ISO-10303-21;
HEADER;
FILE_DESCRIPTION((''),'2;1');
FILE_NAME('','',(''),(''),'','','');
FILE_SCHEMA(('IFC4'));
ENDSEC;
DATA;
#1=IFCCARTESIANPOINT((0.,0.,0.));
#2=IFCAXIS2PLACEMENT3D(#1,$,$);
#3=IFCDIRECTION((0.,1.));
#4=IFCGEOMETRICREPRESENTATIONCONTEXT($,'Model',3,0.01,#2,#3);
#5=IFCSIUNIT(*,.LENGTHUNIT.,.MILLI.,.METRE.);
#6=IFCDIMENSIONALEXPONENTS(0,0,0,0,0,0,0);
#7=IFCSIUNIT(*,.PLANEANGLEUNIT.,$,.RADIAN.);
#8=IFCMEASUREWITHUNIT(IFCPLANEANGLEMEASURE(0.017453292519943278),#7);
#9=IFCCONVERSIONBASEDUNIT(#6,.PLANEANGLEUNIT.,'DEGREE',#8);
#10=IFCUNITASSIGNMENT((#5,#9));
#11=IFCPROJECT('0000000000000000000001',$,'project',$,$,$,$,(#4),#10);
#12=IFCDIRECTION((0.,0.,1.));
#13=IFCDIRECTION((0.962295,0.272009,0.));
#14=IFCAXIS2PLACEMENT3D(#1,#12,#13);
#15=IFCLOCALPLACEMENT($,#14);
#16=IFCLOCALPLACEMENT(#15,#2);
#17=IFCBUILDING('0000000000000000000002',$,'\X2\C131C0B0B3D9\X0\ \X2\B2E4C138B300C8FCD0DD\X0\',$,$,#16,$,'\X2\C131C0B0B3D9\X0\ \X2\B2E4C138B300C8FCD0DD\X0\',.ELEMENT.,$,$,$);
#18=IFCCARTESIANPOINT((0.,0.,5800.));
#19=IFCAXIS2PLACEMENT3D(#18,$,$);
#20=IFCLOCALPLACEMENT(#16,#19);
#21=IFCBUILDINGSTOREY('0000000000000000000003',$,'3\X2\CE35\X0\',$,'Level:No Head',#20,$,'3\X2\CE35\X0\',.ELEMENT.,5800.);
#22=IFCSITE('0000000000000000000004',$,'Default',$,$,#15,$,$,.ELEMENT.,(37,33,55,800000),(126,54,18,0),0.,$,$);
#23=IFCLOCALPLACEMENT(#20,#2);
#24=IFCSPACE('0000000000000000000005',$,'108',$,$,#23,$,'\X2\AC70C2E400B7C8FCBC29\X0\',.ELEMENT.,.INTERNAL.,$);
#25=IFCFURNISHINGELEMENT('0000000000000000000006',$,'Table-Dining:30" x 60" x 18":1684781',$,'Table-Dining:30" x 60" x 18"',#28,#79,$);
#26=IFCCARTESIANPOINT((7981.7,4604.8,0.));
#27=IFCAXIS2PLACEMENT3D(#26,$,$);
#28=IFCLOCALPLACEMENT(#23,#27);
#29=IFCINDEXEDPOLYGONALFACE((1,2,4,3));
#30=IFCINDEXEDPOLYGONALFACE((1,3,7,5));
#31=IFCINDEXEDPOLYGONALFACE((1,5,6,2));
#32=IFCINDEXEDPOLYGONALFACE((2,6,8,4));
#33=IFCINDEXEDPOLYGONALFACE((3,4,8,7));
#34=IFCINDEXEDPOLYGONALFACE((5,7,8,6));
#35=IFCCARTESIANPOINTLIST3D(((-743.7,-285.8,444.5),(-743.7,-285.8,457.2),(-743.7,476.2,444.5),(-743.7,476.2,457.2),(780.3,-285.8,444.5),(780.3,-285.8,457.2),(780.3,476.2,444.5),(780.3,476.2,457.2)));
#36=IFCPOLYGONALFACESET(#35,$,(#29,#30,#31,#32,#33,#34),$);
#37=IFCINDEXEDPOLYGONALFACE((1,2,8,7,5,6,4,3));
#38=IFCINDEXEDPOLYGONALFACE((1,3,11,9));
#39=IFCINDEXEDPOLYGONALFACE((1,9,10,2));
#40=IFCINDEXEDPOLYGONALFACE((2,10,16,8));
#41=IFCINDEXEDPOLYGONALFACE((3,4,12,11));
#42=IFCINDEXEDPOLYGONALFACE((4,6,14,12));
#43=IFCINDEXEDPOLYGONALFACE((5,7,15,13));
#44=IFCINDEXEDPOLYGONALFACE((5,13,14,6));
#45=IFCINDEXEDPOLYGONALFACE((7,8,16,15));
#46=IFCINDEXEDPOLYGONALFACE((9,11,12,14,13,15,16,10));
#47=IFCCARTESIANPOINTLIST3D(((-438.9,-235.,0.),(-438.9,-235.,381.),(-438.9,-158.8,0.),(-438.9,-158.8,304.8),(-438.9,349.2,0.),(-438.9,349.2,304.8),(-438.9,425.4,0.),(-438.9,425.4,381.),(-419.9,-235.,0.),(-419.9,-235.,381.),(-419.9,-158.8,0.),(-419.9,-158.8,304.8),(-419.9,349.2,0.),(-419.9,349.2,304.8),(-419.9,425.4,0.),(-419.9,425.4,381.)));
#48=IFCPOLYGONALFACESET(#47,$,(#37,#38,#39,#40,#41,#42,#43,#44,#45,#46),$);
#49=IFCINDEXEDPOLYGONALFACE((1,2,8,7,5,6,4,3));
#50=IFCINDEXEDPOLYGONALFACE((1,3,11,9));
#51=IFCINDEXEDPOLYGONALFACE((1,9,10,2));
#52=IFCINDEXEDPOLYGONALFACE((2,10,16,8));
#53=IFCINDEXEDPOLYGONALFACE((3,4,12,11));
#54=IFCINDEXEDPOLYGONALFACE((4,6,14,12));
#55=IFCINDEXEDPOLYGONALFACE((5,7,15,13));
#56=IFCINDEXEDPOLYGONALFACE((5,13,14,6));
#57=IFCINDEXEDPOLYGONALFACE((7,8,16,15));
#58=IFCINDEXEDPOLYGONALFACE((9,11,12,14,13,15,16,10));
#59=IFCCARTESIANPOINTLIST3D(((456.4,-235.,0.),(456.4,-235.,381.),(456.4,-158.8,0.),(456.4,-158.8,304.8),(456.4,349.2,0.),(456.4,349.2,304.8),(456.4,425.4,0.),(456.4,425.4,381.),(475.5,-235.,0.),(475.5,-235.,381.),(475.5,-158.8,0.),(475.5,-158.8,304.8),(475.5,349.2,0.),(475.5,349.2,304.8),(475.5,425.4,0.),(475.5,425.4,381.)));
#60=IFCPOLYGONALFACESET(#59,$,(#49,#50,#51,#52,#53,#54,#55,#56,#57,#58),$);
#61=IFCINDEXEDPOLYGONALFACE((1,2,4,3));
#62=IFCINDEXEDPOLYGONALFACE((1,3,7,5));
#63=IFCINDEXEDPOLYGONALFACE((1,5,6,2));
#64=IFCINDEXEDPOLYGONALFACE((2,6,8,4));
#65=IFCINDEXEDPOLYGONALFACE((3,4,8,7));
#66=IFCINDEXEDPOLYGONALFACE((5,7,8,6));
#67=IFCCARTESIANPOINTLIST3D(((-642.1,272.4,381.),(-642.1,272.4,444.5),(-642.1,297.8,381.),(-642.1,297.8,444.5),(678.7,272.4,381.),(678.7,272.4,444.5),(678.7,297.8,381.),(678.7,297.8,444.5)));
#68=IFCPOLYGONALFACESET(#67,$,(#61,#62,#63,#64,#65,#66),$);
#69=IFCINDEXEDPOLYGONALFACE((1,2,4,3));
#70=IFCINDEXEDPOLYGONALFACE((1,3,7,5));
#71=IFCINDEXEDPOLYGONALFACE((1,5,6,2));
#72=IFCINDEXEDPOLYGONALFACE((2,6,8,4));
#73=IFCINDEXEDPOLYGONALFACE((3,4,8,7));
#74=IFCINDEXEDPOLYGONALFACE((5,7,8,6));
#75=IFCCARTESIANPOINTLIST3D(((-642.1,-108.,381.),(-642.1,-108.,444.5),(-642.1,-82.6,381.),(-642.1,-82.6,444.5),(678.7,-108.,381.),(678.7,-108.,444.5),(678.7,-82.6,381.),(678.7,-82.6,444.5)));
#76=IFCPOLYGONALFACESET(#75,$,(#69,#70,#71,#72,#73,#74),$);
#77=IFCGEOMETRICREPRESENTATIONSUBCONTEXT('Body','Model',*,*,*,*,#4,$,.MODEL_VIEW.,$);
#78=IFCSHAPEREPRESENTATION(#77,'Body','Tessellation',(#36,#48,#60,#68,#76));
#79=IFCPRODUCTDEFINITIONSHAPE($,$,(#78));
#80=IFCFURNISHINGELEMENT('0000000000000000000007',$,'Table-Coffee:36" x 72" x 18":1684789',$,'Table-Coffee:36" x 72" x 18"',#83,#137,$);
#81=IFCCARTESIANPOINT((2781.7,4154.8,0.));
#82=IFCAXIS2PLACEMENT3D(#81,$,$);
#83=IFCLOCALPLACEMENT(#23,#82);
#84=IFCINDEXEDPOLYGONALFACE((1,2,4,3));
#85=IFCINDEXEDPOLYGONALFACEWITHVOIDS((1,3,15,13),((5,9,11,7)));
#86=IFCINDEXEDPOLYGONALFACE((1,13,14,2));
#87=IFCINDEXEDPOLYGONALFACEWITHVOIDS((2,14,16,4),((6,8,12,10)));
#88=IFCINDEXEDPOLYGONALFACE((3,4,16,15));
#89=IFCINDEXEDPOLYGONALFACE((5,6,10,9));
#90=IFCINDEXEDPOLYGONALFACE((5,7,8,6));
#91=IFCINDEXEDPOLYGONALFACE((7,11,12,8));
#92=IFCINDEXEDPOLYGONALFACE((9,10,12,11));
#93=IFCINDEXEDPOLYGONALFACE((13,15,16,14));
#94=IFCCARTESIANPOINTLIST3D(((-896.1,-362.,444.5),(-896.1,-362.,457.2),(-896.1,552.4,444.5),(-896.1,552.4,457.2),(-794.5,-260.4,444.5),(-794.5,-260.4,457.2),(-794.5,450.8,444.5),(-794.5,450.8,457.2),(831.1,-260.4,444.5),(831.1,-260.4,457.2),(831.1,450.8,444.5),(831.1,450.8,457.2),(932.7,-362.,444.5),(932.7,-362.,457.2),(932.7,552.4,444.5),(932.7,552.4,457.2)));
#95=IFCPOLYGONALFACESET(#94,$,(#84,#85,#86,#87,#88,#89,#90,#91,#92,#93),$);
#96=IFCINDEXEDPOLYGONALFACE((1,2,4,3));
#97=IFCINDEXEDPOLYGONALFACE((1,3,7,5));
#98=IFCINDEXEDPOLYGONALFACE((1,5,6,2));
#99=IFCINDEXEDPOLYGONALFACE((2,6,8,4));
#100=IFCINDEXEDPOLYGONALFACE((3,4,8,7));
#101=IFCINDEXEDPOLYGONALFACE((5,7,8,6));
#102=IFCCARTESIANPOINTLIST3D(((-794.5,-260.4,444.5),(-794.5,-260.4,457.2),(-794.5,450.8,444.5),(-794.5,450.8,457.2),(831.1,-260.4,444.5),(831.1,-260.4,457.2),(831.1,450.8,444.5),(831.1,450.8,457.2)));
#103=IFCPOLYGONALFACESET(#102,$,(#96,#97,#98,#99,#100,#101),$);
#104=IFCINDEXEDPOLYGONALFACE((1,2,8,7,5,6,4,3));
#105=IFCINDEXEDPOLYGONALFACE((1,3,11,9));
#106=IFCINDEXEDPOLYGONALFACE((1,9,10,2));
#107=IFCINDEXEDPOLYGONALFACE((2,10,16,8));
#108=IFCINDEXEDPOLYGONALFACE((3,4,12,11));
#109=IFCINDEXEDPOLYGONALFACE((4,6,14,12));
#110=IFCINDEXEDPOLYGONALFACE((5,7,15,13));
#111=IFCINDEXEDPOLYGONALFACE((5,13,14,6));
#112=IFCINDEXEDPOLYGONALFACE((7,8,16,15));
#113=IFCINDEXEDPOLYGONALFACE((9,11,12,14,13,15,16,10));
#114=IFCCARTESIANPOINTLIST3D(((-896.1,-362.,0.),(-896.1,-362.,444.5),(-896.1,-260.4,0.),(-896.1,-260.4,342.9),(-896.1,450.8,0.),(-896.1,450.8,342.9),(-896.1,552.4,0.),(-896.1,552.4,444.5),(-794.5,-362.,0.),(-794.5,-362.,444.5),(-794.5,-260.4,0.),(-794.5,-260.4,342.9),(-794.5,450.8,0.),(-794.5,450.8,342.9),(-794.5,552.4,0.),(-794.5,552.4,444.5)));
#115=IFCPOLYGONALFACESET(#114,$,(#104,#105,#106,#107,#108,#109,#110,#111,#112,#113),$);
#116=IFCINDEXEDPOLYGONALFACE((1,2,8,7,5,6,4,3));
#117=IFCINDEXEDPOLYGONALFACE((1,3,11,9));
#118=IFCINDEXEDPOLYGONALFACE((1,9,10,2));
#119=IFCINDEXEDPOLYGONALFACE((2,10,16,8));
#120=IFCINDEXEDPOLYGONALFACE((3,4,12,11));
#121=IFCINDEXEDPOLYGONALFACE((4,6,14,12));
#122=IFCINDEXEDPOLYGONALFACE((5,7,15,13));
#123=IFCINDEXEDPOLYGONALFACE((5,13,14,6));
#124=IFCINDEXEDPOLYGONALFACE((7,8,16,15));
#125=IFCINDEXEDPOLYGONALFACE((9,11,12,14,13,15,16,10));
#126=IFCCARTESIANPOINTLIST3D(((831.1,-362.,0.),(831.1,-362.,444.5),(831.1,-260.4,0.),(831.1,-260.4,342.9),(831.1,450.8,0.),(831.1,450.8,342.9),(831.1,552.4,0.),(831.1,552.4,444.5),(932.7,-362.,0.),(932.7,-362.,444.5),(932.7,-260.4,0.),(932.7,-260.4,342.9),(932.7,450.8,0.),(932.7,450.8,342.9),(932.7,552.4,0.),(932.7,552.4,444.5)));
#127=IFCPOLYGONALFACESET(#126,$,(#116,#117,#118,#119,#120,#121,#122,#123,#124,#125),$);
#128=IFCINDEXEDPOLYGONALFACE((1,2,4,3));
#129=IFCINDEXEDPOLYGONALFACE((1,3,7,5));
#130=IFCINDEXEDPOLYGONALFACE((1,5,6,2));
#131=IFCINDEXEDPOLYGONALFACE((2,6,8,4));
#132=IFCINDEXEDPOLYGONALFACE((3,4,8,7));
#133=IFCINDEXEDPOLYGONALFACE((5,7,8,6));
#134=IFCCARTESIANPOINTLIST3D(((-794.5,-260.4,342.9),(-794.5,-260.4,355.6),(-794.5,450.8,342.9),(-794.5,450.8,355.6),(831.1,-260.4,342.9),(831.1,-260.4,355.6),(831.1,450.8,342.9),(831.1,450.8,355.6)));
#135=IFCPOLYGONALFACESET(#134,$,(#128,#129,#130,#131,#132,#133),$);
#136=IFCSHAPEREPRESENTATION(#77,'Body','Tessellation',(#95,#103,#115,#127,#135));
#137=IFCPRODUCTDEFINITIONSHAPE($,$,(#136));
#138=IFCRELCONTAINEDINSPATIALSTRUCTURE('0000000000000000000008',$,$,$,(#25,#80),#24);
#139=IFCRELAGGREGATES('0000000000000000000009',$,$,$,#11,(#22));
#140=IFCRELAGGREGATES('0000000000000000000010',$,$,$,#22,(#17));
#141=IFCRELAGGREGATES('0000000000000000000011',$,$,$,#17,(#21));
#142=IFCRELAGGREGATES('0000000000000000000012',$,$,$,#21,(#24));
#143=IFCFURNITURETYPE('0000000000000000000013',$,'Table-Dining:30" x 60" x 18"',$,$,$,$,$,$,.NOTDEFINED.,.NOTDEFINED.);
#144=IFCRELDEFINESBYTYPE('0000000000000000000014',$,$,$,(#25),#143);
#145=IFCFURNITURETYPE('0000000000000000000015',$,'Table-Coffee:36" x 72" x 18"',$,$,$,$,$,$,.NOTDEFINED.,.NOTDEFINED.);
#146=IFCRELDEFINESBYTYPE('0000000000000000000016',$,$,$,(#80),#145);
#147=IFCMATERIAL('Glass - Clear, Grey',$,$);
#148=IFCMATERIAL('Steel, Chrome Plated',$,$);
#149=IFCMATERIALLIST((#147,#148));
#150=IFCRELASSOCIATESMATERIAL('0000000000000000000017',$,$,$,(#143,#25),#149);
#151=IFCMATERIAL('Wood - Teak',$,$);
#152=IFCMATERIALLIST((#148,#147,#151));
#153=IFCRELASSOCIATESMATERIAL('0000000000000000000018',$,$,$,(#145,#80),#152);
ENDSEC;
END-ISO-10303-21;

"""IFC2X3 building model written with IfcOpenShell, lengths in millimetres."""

from ifc_helpers import new_model, entity, si_unit, converted_unit, direction, frame, frame_2d, origin, origin_2d_with_axis, place, context, subcontext, project, spatial, polyline, rectangle, outline, extrude, source, transform, mapped, material, material_list, type_object, type_shapes, element, save


model = new_model("IFC2X3")

# Units and contexts
model_context = context("Model", 3, precision=0.01, world=origin(), true_north=direction((0.0, 1.0)))
body_context = subcontext(model_context, "Body", "Model", "MODEL_VIEW")
ifc_project = project(units=[si_unit("LENGTHUNIT", "METRE", prefix="MILLI"), converted_unit("PLANEANGLEUNIT", "DEGREE", entity("IfcPlaneAngleMeasure", 0.017453292519943278), si_unit("PLANEANGLEUNIT", "RADIAN"), dimensions=[0, 0, 0, 0, 0, 0, 0])], contexts=[model_context])

# Site, building, storey
site_placement = place(None, frame((0.0, 0.0, 0.0), z_axis=(0.0, 0.0, 1.0), x_axis=(0.962295, 0.272009, 0.0)))
site = spatial("IfcSite", under=ifc_project, at=site_placement, Name="Default", CompositionType="ELEMENT", RefLatitude=(37, 33, 55, 800000), RefLongitude=(126, 54, 18, 0), RefElevation=0.0)
building_placement = place(site_placement, origin())
building = spatial("IfcBuilding", under=site, at=building_placement, Name="성산동 다세대주택", LongName="성산동 다세대주택", CompositionType="ELEMENT")
storey_placement = place(building_placement, frame((0.0, 0.0, 5800.0)))
storey = spatial("IfcBuildingStorey", under=building, at=storey_placement, Name="3층", ObjectType="Level:No Head", LongName="3층", CompositionType="ELEMENT", Elevation=5800.0)

# Shared definitions
space_1_placement = place(storey_placement, origin())
space_1 = spatial("IfcSpace", under=storey, at=space_1_placement, Name="108", LongName="거실·주방", CompositionType="ELEMENT", InteriorOrExteriorSpace="INTERNAL")

# Furnishing elements
ifc_material_1 = material(Name="Glass - Clear, Grey")
ifc_material_2 = material(Name="Steel, Chrome Plated")
ifc_material_list_1 = material_list([ifc_material_1, ifc_material_2])
furniture_type_1 = type_object("IfcFurnitureType", Name="Table-Dining:30\" x 60\" x 18\"", AssemblyPlace="NOTDEFINED", material=ifc_material_list_1)
shared_shape_1 = source(origin(), body_context, "Body", "SweptSolid", [
    extrude(rectangle(XDim=1524.0, YDim=762.0, at=frame_2d((0.0, 0.0), x_axis=(1.0, 0.0))), frame((18.3, 95.2, 444.5), z_axis=(0.0, 0.0, 1.0), x_axis=(-1.0, 0.0, 0.0)), (0.0, 0.0, 1.0), 12.7),
    extrude(outline(polyline([(-330.2, -209.5), (330.2, -209.5), (330.2, 171.4), (254.0, 171.4), (254.0, -133.3), (-254.0, -133.3), (-254.0, 171.4), (-330.2, 171.4), (-330.2, -209.5)])), frame((-438.9, 95.2, 171.4), z_axis=(1.0, 0.0, 0.0), x_axis=(0.0, -1.0, 0.0)), (0.0, 0.0, 1.0), 19.1),
    extrude(outline(polyline([(-171.4, -330.2), (209.5, -330.2), (209.5, 330.2), (-171.4, 330.2), (-171.4, 254.0), (133.3, 254.0), (133.3, -254.0), (-171.4, -254.0), (-171.4, -330.2)])), frame((456.4, 95.2, 171.4), z_axis=(1.0, 0.0, 0.0), x_axis=(0.0, 0.0, 1.0)), (0.0, 0.0, 1.0), 19.1),
    extrude(rectangle(XDim=1320.8, YDim=25.4, at=frame_2d((0.0, 0.0), x_axis=(1.0, 0.0))), frame((18.3, 285.1, 381.0), z_axis=(0.0, 0.0, 1.0), x_axis=(-1.0, 0.0, 0.0)), (0.0, 0.0, 1.0), 63.5),
    extrude(rectangle(XDim=1320.8, YDim=25.4, at=origin_2d_with_axis()), frame((18.3, -95.3, 381.0), z_axis=(0.0, 0.0, 1.0), x_axis=(-1.0, 0.0, 0.0)), (0.0, 0.0, 1.0), 63.5),
])
type_shapes(furniture_type_1, [shared_shape_1])
furnishing_1_placement = place(space_1_placement, frame((7981.7, 4604.8, 0.0)))
element("IfcFurnishingElement", 1, at=furnishing_1_placement, inside=space_1, type_object=furniture_type_1, material=ifc_material_list_1, Name="Table-Dining:30\" x 60\" x 18\":1684781", ObjectType="Table-Dining:30\" x 60\" x 18\"", context=body_context, shape_type="MappedRepresentation", body=[
    mapped(shared_shape_1, transform((0.0, 0.0, 0.0), scale=1.0)),
])
ifc_material_3 = material(Name="Wood - Teak")
ifc_material_list_2 = material_list([ifc_material_2, ifc_material_1, ifc_material_3])
furniture_type_2 = type_object("IfcFurnitureType", Name="Table-Coffee:36\" x 72\" x 18\"", AssemblyPlace="NOTDEFINED", material=ifc_material_list_2)
shared_shape_2 = source(origin(), body_context, "Body", "SweptSolid", [
    extrude(outline(polyline([(-914.4, -457.2), (914.4, -457.2), (914.4, 457.2), (-914.4, 457.2), (-914.4, -457.2)]), holes=[polyline([(-812.8, -355.6), (-812.8, 355.6), (812.8, 355.6), (812.8, -355.6), (-812.8, -355.6)])]), frame((18.3, 95.2, 444.5), z_axis=(0.0, 0.0, 1.0), x_axis=(-1.0, 0.0, 0.0)), (0.0, 0.0, 1.0), 12.7),
    extrude(rectangle(XDim=1625.6, YDim=711.2, at=origin_2d_with_axis()), frame((18.3, 95.2, 444.5), z_axis=(0.0, 0.0, 1.0), x_axis=(-1.0, 0.0, 0.0)), (0.0, 0.0, 1.0), 12.7),
    extrude(outline(polyline([(-457.2, -247.7), (457.2, -247.7), (457.2, 196.9), (355.6, 196.9), (355.6, -146.0), (-355.6, -146.0), (-355.6, 196.9), (-457.2, 196.9), (-457.2, -247.7)])), frame((-896.1, 95.2, 196.9), z_axis=(1.0, 0.0, 0.0), x_axis=(0.0, -1.0, 0.0)), (0.0, 0.0, 1.0), 101.6),
    extrude(outline(polyline([(-196.8, -457.2), (247.6, -457.2), (247.6, 457.2), (-196.8, 457.2), (-196.8, 355.6), (146.1, 355.6), (146.1, -355.6), (-196.8, -355.6), (-196.8, -457.2)])), frame((831.1, 95.2, 196.8), z_axis=(1.0, 0.0, 0.0), x_axis=(0.0, 0.0, 1.0)), (0.0, 0.0, 1.0), 101.6),
    extrude(rectangle(XDim=1625.6, YDim=711.2, at=origin_2d_with_axis()), frame((18.3, 95.2, 342.9), z_axis=(0.0, 0.0, 1.0), x_axis=(-1.0, 0.0, 0.0)), (0.0, 0.0, 1.0), 12.7),
])
type_shapes(furniture_type_2, [shared_shape_2])
furnishing_2_placement = place(space_1_placement, frame((2781.7, 4154.8, 0.0)))
element("IfcFurnishingElement", 2, at=furnishing_2_placement, inside=space_1, type_object=furniture_type_2, material=ifc_material_list_2, Name="Table-Coffee:36\" x 72\" x 18\":1684789", ObjectType="Table-Coffee:36\" x 72\" x 18\"", context=body_context, shape_type="MappedRepresentation", body=[
    mapped(shared_shape_2, transform((0.0, 0.0, 0.0), scale=1.0)),
])

save(model, "model.ifc")
